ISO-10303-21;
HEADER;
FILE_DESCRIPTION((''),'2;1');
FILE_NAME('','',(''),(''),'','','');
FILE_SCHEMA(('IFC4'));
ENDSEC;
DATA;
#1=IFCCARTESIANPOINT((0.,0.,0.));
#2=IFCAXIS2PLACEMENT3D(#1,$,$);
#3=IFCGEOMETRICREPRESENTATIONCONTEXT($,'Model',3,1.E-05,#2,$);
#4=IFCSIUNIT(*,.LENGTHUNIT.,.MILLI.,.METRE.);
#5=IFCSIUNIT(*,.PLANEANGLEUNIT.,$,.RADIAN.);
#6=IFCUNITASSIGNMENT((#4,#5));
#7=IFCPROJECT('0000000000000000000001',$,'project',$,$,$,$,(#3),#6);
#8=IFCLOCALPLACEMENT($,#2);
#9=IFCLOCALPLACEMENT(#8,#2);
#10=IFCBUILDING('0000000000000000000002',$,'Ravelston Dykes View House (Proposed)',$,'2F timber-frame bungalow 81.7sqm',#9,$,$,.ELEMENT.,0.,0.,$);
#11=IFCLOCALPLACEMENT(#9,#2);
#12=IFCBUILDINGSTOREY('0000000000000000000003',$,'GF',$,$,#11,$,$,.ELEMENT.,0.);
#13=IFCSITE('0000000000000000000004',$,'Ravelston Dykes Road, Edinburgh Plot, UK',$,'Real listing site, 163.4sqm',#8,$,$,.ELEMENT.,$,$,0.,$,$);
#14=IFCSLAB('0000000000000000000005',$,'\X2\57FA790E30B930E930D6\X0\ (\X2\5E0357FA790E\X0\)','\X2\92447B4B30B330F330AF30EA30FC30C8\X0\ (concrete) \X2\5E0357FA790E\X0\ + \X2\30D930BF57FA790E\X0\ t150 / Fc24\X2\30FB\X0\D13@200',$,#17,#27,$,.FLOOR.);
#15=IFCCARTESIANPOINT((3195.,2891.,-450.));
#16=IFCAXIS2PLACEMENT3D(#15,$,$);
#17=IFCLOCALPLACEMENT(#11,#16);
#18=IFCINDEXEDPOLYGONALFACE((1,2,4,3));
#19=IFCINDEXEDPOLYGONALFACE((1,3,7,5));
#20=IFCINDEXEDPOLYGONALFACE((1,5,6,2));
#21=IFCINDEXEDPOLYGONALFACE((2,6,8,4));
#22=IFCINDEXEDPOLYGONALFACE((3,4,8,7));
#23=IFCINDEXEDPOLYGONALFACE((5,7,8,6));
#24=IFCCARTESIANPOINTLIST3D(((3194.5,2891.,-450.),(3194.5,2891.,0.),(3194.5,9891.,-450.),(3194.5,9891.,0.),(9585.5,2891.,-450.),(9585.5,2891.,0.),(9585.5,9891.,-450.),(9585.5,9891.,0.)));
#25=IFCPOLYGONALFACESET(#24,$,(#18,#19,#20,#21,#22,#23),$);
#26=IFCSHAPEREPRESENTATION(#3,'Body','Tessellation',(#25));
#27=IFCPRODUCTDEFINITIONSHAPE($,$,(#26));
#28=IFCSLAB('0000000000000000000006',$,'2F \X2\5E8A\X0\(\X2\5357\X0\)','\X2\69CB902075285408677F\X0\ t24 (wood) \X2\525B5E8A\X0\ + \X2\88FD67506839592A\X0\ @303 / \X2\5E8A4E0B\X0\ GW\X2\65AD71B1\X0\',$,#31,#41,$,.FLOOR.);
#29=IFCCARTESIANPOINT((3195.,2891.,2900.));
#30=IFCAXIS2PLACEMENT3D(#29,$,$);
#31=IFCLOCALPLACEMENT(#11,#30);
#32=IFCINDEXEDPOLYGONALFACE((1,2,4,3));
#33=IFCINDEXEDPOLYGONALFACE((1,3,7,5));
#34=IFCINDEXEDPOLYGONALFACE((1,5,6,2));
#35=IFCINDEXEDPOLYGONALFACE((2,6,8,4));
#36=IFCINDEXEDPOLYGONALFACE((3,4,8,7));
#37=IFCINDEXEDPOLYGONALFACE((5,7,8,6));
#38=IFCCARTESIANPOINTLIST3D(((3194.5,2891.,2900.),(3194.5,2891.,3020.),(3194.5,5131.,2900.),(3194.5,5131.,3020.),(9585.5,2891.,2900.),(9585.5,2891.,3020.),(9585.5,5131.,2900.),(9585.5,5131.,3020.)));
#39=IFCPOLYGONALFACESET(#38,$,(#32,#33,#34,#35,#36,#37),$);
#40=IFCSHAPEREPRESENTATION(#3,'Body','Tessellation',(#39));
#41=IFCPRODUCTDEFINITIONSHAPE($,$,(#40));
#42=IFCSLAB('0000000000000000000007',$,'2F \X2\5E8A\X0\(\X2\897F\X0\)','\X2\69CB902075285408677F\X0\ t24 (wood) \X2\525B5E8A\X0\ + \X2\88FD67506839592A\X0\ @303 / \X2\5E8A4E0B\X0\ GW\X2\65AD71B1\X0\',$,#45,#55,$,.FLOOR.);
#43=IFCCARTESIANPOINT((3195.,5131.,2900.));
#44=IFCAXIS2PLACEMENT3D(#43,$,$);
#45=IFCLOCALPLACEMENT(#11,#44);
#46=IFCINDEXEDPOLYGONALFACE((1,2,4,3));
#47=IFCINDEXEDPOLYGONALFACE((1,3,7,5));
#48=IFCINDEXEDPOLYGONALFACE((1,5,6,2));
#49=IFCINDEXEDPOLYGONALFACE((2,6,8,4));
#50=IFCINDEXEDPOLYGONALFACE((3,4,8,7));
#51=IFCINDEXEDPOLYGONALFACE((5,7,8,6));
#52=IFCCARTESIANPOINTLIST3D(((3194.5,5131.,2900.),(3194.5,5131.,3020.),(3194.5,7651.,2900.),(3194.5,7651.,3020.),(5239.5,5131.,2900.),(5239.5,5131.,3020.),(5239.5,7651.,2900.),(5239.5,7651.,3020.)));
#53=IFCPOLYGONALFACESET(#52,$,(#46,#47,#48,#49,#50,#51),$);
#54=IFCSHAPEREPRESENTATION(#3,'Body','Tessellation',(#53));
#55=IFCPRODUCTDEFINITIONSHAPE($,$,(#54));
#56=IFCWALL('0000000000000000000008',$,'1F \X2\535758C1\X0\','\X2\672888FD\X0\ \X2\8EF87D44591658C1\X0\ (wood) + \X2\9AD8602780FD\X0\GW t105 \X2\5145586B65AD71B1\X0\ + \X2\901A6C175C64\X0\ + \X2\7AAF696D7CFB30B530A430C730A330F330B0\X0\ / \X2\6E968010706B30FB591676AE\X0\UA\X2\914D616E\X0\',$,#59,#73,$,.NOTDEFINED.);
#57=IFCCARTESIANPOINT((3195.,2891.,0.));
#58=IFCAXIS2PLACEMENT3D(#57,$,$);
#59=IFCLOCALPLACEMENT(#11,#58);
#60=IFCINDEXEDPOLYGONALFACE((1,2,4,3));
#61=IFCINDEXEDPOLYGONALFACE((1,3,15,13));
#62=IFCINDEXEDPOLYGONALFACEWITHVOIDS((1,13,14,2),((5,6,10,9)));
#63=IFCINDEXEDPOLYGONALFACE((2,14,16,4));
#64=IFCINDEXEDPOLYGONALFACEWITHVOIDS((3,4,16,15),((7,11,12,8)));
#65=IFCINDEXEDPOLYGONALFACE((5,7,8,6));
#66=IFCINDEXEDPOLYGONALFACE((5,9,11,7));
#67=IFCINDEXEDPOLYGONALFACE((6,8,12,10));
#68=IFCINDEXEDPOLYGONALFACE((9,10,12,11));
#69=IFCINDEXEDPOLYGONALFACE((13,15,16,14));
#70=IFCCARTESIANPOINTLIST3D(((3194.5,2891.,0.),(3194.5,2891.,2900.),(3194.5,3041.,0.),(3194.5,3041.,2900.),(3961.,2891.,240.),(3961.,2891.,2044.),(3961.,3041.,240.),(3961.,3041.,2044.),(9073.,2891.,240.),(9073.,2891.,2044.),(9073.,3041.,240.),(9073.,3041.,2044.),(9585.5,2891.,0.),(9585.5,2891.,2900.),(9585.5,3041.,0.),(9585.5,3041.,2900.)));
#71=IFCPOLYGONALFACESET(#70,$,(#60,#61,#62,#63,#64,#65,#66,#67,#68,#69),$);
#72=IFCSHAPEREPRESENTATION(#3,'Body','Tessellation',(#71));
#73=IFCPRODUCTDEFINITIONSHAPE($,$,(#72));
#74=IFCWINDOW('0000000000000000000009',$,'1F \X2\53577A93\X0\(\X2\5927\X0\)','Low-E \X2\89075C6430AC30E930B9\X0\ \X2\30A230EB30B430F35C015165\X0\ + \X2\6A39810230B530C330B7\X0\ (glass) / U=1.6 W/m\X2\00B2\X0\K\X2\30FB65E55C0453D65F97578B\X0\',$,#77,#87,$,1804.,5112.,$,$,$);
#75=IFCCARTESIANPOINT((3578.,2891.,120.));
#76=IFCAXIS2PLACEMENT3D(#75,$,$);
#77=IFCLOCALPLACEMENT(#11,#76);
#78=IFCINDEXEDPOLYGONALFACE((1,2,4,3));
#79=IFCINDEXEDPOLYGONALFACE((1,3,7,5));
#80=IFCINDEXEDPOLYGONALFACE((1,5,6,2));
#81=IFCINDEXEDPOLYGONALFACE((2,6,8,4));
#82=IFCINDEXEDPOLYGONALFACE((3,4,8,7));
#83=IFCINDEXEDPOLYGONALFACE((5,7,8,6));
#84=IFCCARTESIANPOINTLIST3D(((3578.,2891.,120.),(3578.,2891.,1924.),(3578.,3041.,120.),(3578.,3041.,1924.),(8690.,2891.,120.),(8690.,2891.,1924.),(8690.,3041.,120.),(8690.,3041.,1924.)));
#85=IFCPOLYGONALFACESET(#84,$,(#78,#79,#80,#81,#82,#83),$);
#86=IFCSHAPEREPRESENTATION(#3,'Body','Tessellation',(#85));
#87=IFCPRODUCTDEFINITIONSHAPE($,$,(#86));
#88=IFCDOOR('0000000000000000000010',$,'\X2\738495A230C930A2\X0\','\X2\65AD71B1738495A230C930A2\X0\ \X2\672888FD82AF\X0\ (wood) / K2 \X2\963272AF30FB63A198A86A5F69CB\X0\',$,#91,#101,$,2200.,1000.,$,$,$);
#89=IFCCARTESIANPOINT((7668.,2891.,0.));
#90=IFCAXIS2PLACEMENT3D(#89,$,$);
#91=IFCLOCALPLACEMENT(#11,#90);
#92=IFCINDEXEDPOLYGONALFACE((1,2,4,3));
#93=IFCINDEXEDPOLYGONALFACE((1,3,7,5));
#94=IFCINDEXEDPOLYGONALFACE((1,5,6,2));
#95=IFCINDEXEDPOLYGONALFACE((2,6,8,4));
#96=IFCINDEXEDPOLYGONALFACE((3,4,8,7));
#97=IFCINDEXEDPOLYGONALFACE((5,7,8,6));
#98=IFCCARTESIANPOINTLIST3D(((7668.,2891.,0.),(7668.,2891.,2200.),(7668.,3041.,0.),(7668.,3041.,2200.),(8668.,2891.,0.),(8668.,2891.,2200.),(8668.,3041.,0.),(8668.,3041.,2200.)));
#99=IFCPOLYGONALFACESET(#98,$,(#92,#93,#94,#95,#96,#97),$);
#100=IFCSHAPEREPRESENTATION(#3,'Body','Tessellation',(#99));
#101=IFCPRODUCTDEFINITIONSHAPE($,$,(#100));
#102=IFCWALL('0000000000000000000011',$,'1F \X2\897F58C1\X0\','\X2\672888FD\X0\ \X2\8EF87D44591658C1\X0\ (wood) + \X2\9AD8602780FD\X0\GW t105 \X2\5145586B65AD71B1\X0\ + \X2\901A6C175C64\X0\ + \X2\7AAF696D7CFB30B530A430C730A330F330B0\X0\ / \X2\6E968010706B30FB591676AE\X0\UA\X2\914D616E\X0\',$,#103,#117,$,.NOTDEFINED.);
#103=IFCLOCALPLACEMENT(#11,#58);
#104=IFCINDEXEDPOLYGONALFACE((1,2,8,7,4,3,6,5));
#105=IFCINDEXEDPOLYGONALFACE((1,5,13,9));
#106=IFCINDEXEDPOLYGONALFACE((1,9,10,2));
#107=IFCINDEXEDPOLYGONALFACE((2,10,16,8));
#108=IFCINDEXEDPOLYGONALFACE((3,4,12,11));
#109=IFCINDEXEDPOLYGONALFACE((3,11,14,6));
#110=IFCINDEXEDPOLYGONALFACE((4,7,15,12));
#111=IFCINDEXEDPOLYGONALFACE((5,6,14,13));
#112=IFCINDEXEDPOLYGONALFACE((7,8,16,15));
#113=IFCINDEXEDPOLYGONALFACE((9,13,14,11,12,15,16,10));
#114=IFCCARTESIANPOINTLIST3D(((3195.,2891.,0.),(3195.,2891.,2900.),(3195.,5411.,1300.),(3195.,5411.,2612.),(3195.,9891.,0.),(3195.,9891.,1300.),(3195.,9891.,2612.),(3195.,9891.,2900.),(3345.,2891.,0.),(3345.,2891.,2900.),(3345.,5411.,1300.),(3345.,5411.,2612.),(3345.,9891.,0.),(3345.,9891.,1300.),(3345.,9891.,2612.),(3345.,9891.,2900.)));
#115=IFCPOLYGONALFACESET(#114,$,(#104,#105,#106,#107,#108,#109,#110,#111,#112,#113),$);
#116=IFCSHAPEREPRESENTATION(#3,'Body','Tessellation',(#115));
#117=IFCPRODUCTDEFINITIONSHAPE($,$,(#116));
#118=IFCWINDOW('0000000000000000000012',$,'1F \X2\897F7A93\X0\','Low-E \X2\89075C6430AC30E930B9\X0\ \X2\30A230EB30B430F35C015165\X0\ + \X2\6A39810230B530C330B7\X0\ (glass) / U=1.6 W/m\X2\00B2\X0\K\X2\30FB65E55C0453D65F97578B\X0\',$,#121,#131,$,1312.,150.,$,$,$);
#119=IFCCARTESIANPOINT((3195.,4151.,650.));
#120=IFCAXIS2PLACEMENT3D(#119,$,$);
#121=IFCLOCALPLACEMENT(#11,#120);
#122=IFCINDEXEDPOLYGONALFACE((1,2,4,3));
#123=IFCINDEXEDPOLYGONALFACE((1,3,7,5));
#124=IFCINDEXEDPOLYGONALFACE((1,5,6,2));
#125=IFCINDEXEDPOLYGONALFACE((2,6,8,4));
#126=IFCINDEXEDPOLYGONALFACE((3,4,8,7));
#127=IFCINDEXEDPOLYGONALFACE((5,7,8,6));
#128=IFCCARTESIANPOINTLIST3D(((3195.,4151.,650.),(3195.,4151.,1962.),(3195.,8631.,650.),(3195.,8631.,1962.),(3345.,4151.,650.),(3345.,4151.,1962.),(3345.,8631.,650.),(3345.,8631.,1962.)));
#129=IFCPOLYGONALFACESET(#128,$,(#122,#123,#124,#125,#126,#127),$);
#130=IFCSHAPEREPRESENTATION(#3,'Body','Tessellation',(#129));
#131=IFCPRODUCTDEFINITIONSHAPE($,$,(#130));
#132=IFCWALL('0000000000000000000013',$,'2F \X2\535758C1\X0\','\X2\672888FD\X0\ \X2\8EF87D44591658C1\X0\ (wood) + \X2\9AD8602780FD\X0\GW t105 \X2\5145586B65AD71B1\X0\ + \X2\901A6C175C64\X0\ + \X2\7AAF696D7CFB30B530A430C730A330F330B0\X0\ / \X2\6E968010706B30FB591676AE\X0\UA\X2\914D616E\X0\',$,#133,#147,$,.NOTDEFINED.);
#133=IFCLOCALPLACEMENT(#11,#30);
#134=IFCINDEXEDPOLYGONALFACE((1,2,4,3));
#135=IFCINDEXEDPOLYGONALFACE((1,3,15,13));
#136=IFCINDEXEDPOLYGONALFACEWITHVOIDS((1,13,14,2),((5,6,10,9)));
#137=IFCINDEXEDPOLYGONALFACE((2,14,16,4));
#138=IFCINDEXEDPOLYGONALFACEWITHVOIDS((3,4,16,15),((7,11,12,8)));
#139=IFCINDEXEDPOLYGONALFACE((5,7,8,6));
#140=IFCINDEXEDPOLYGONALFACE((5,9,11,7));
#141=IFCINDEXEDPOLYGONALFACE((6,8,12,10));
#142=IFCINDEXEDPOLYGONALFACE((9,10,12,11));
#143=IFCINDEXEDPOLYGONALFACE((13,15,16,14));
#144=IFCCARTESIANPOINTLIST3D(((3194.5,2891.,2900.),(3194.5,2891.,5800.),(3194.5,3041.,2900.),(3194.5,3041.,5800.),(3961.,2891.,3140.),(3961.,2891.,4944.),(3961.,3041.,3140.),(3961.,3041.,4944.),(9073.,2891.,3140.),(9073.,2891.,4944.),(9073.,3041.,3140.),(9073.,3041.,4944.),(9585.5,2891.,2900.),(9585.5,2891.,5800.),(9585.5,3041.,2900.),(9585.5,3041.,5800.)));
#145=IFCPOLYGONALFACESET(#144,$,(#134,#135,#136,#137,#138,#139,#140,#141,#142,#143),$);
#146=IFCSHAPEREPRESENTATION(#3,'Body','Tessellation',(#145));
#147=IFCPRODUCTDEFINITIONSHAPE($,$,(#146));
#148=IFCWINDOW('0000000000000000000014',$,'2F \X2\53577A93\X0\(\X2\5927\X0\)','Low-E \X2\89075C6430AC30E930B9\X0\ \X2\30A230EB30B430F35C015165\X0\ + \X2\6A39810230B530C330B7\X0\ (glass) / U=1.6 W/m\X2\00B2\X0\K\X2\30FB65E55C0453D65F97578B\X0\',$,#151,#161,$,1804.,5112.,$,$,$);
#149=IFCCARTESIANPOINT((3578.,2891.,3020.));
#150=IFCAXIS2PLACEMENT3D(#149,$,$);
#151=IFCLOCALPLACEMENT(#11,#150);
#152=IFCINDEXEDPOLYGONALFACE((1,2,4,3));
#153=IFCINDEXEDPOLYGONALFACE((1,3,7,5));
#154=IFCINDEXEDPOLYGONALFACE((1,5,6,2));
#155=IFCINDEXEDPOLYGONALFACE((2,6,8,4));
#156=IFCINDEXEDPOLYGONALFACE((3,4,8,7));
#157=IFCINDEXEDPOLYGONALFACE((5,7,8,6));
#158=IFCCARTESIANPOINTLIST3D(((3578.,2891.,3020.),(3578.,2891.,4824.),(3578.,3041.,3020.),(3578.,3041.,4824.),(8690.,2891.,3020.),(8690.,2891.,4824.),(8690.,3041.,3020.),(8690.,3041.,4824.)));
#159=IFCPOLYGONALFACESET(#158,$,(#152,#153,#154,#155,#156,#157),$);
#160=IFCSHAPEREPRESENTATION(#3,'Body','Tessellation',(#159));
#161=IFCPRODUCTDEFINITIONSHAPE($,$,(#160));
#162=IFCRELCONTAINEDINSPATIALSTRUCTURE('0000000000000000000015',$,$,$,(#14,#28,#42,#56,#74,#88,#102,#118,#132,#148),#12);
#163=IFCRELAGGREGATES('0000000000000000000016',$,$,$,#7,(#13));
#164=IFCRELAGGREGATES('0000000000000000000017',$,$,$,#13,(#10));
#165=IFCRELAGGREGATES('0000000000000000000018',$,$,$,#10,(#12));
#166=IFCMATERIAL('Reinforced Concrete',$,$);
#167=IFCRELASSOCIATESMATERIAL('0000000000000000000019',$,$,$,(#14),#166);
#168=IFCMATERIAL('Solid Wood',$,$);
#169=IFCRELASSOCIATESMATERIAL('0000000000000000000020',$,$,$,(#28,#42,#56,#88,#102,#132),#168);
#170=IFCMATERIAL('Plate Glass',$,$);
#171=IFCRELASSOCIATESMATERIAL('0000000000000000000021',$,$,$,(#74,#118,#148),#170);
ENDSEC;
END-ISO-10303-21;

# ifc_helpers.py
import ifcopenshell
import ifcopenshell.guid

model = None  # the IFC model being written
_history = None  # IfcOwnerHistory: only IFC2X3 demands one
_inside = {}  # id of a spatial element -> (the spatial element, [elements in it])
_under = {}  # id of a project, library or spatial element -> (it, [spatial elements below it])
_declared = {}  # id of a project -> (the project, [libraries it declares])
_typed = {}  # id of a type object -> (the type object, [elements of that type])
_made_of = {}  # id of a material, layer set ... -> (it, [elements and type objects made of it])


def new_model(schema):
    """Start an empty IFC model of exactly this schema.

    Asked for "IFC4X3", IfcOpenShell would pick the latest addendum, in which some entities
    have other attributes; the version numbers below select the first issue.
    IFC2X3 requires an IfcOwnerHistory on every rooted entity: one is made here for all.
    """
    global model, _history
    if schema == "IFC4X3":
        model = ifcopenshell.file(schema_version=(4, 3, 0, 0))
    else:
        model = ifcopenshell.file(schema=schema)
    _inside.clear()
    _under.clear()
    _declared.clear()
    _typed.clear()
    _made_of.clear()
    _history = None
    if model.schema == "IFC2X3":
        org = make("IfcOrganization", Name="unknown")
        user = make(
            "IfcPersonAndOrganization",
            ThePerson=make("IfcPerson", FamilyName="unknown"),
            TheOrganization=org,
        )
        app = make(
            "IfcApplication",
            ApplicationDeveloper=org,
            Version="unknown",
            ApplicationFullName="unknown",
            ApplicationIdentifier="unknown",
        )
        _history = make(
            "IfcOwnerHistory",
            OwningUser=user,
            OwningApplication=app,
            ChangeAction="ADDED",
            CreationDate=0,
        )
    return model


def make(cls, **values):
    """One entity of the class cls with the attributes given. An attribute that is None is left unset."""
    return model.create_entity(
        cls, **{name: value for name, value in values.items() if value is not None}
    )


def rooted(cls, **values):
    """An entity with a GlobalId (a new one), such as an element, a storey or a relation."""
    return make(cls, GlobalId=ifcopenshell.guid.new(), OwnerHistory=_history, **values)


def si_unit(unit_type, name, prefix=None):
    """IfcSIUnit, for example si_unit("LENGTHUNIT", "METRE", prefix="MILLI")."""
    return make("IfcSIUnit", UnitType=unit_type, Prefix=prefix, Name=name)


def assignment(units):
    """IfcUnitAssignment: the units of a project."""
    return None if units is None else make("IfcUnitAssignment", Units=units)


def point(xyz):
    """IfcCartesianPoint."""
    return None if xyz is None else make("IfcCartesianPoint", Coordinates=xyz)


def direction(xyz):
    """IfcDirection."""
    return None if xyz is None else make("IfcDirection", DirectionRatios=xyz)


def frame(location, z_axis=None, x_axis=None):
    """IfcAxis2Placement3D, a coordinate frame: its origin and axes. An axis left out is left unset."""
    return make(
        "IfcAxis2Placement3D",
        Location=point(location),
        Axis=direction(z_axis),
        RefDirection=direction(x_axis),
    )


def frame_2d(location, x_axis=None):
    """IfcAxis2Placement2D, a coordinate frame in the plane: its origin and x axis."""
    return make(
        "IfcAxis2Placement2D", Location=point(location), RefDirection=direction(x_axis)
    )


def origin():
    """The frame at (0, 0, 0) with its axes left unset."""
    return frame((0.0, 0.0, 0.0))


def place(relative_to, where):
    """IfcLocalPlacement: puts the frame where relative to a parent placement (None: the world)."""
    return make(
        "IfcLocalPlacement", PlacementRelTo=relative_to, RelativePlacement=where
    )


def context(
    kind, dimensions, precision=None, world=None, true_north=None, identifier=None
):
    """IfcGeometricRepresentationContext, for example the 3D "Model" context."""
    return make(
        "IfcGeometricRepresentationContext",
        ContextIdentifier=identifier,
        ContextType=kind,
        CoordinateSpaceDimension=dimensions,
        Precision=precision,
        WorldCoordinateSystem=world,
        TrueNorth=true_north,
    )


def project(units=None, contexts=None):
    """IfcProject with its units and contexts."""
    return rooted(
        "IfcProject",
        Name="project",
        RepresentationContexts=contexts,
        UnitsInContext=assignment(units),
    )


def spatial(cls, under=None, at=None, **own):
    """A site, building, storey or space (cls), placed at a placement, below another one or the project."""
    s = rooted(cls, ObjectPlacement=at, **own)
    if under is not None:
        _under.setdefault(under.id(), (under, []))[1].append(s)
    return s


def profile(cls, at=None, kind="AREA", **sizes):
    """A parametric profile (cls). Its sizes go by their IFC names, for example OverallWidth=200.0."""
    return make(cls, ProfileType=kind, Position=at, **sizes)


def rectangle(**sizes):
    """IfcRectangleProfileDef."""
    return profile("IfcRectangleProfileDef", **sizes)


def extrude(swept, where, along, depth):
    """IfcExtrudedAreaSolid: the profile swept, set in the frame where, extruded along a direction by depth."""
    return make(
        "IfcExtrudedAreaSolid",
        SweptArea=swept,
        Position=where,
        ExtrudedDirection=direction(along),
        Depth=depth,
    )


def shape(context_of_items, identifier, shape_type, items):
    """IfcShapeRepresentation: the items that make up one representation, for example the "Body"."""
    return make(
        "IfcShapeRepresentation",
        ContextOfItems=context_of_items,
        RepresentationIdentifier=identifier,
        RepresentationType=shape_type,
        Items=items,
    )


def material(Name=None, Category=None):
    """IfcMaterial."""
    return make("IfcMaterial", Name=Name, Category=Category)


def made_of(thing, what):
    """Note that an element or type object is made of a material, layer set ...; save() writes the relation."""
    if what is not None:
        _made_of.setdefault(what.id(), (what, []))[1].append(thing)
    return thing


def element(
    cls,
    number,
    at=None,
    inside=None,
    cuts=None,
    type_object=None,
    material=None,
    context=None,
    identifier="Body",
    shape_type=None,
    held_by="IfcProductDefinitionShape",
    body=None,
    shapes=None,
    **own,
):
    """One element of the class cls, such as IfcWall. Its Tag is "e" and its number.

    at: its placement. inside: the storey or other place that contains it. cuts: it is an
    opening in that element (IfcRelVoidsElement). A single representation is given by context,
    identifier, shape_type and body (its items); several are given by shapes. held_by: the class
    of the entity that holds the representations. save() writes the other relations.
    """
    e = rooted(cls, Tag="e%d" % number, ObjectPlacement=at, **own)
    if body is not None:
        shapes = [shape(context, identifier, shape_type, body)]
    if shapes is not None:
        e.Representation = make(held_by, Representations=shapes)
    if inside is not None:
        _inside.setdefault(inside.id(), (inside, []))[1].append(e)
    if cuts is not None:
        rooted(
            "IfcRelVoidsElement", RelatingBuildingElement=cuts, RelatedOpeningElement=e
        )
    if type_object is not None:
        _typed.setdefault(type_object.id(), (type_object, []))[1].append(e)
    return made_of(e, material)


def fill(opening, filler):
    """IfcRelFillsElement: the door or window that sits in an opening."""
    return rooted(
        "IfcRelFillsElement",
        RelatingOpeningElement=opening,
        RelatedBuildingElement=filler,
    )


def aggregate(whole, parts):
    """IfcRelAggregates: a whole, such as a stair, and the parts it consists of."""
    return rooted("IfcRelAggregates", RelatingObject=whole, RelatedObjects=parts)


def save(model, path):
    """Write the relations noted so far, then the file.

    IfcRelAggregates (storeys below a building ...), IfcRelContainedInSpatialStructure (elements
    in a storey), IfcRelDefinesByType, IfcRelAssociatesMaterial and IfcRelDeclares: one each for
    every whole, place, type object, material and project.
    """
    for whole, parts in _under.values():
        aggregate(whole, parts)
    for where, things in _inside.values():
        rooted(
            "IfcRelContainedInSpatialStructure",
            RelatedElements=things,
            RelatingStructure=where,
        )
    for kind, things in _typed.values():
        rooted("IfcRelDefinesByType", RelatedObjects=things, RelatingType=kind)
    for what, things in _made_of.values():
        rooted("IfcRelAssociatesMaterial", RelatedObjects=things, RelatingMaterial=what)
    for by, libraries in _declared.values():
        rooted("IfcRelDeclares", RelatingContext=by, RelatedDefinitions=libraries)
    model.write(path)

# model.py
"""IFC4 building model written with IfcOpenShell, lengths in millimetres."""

from ifc_helpers import new_model, si_unit, frame, frame_2d, origin, place, context, project, spatial, rectangle, extrude, material, element, fill, save


model = new_model("IFC4")

# Units and contexts
model_context = context("Model", 3, precision=1e-05, world=origin())
ifc_project = project(units=[si_unit("LENGTHUNIT", "METRE", prefix="MILLI"), si_unit("PLANEANGLEUNIT", "RADIAN")], contexts=[model_context])

# Site, building, storey
site_placement = place(None, origin())
site = spatial("IfcSite", under=ifc_project, at=site_placement, Name="Ravelston Dykes Road, Edinburgh Plot, UK", ObjectType="Real listing site, 163.4sqm", CompositionType="ELEMENT", RefElevation=0.0)
building_placement = place(site_placement, origin())
building = spatial("IfcBuilding", under=site, at=building_placement, Name="Ravelston Dykes View House (Proposed)", ObjectType="2F timber-frame bungalow 81.7sqm", CompositionType="ELEMENT", ElevationOfRefHeight=0.0, ElevationOfTerrain=0.0)
storey_placement = place(building_placement, origin())
storey = spatial("IfcBuildingStorey", under=building, at=storey_placement, Name="GF", CompositionType="ELEMENT", Elevation=0.0)

# Slabs
ifc_material_1 = material(Name="Reinforced Concrete")
slab_1_placement = place(storey_placement, frame((3195.0, 2891.0, -450.0)))
element("IfcSlab", 1, at=slab_1_placement, inside=storey, material=ifc_material_1, Name="基礎スラブ (布基礎)", Description="鉄筋コンクリート (concrete) 布基礎 + ベタ基礎 t150 / Fc24・D13@200", PredefinedType="FLOOR", context=model_context, shape_type="SweptSolid", body=[
    extrude(rectangle(XDim=6391.0, YDim=7000.0, at=frame_2d((3195.0, 3500.0))), frame((3195.0, 2891.0, -450.0)), (0.0, 0.0, 1.0), 450.0),
])
ifc_material_2 = material(Name="Solid Wood")
slab_2_placement = place(storey_placement, frame((3195.0, 2891.0, 2900.0)))
element("IfcSlab", 2, at=slab_2_placement, inside=storey, material=ifc_material_2, Name="2F 床(南)", Description="構造用合板 t24 (wood) 剛床 + 製材根太 @303 / 床下 GW断熱", PredefinedType="FLOOR", context=model_context, shape_type="SweptSolid", body=[
    extrude(rectangle(XDim=6391.0, YDim=2240.0, at=frame_2d((3195.0, 1120.0))), frame((3195.0, 2891.0, 2900.0)), (0.0, 0.0, 1.0), 120.0),
])
slab_3_placement = place(storey_placement, frame((3195.0, 5131.0, 2900.0)))
element("IfcSlab", 3, at=slab_3_placement, inside=storey, material=ifc_material_2, Name="2F 床(西)", Description="構造用合板 t24 (wood) 剛床 + 製材根太 @303 / 床下 GW断熱", PredefinedType="FLOOR", context=model_context, shape_type="SweptSolid", body=[
    extrude(rectangle(XDim=2045.0, YDim=2520.0, at=frame_2d((1022.0, 1260.0))), frame((3195.0, 5131.0, 2900.0)), (0.0, 0.0, 1.0), 120.0),
])

# Wall, openings, window, door
wall_1_placement = place(storey_placement, frame((3195.0, 2891.0, 0.0)))
wall_1 = element("IfcWall", 4, at=wall_1_placement, inside=storey, material=ifc_material_2, Name="1F 南壁", Description="木製 軸組外壁 (wood) + 高性能GW t105 充填断熱 + 通気層 + 窯業系サイディング / 準耐火・外皮UA配慮", PredefinedType="NOTDEFINED", context=model_context, shape_type="SweptSolid", body=[
    extrude(rectangle(XDim=6391.0, YDim=150.0, at=frame_2d((3195.0, 75.0))), frame((3195.0, 2891.0, 0.0)), (0.0, 0.0, 1.0), 2900.0),
])
opening_1_placement = place(storey_placement, frame((3578.0, 2891.0, 120.0)))
opening_1 = element("IfcOpeningElement", 5, at=opening_1_placement, cuts=wall_1, PredefinedType="NOTDEFINED", context=model_context, shape_type="SweptSolid", body=[
    extrude(rectangle(XDim=5112.0, YDim=150.0, at=frame_2d((2556.0, 75.0))), frame((3578.0, 2891.0, 120.0)), (0.0, 0.0, 1.0), 1804.0),
])
opening_2_placement = place(storey_placement, frame((7668.0, 2891.0, 0.0)))
opening_2 = element("IfcOpeningElement", 6, at=opening_2_placement, cuts=wall_1, PredefinedType="NOTDEFINED", context=model_context, shape_type="SweptSolid", body=[
    extrude(rectangle(XDim=1000.0, YDim=150.0, at=frame_2d((500.0, 75.0))), frame((7668.0, 2891.0, 0.0)), (0.0, 0.0, 1.0), 2200.0),
])
ifc_material_3 = material(Name="Plate Glass")
window_1_placement = place(storey_placement, frame((3578.0, 2891.0, 120.0)))
window_1 = element("IfcWindow", 7, at=window_1_placement, inside=storey, material=ifc_material_3, Name="1F 南窓(大)", Description="Low-E 複層ガラス アルゴン封入 + 樹脂サッシ (glass) / U=1.6 W/m²K・日射取得型", OverallHeight=1804.0, OverallWidth=5112.0, context=model_context, shape_type="SweptSolid", body=[
    extrude(rectangle(XDim=5112.0, YDim=150.0, at=frame_2d((2556.0, 75.0))), frame((3578.0, 2891.0, 120.0)), (0.0, 0.0, 1.0), 1804.0),
])
fill(opening_1, window_1)
door_placement = place(storey_placement, frame((7668.0, 2891.0, 0.0)))
door = element("IfcDoor", 8, at=door_placement, inside=storey, material=ifc_material_2, Name="玄関ドア", Description="断熱玄関ドア 木製芯 (wood) / K2 防犯・採風機構", OverallHeight=2200.0, OverallWidth=1000.0, context=model_context, shape_type="SweptSolid", body=[
    extrude(rectangle(XDim=1000.0, YDim=150.0, at=frame_2d((500.0, 75.0))), frame((7668.0, 2891.0, 0.0)), (0.0, 0.0, 1.0), 2200.0),
])
fill(opening_2, door)

# Walls, openings, windows
wall_2_placement = place(storey_placement, frame((3195.0, 2891.0, 0.0)))
wall_2 = element("IfcWall", 9, at=wall_2_placement, inside=storey, material=ifc_material_2, Name="1F 西壁", Description="木製 軸組外壁 (wood) + 高性能GW t105 充填断熱 + 通気層 + 窯業系サイディング / 準耐火・外皮UA配慮", PredefinedType="NOTDEFINED", context=model_context, shape_type="SweptSolid", body=[
    extrude(rectangle(XDim=150.0, YDim=7000.0, at=frame_2d((75.0, 3500.0))), frame((3195.0, 2891.0, 0.0)), (0.0, 0.0, 1.0), 2900.0),
])
opening_3_placement = place(storey_placement, frame((3195.0, 4151.0, 650.0)))
opening_3 = element("IfcOpeningElement", 10, at=opening_3_placement, cuts=wall_2, PredefinedType="NOTDEFINED", context=model_context, shape_type="SweptSolid", body=[
    extrude(rectangle(XDim=150.0, YDim=4480.0, at=frame_2d((75.0, 2240.0))), frame((3195.0, 4151.0, 650.0)), (0.0, 0.0, 1.0), 1312.0),
])
window_2_placement = place(storey_placement, frame((3195.0, 4151.0, 650.0)))
window_2 = element("IfcWindow", 11, at=window_2_placement, inside=storey, material=ifc_material_3, Name="1F 西窓", Description="Low-E 複層ガラス アルゴン封入 + 樹脂サッシ (glass) / U=1.6 W/m²K・日射取得型", OverallHeight=1312.0, OverallWidth=150.0, context=model_context, shape_type="SweptSolid", body=[
    extrude(rectangle(XDim=150.0, YDim=4480.0, at=frame_2d((75.0, 2240.0))), frame((3195.0, 4151.0, 650.0)), (0.0, 0.0, 1.0), 1312.0),
])
fill(opening_3, window_2)
wall_3_placement = place(storey_placement, frame((3195.0, 2891.0, 2900.0)))
wall_3 = element("IfcWall", 12, at=wall_3_placement, inside=storey, material=ifc_material_2, Name="2F 南壁", Description="木製 軸組外壁 (wood) + 高性能GW t105 充填断熱 + 通気層 + 窯業系サイディング / 準耐火・外皮UA配慮", PredefinedType="NOTDEFINED", context=model_context, shape_type="SweptSolid", body=[
    extrude(rectangle(XDim=6391.0, YDim=150.0, at=frame_2d((3195.0, 75.0))), frame((3195.0, 2891.0, 2900.0)), (0.0, 0.0, 1.0), 2900.0),
])
opening_4_placement = place(storey_placement, frame((3578.0, 2891.0, 3020.0)))
opening_4 = element("IfcOpeningElement", 13, at=opening_4_placement, cuts=wall_3, PredefinedType="NOTDEFINED", context=model_context, shape_type="SweptSolid", body=[
    extrude(rectangle(XDim=5112.0, YDim=150.0, at=frame_2d((2556.0, 75.0))), frame((3578.0, 2891.0, 3020.0)), (0.0, 0.0, 1.0), 1804.0),
])
window_3_placement = place(storey_placement, frame((3578.0, 2891.0, 3020.0)))
window_3 = element("IfcWindow", 14, at=window_3_placement, inside=storey, material=ifc_material_3, Name="2F 南窓(大)", Description="Low-E 複層ガラス アルゴン封入 + 樹脂サッシ (glass) / U=1.6 W/m²K・日射取得型", OverallHeight=1804.0, OverallWidth=5112.0, context=model_context, shape_type="SweptSolid", body=[
    extrude(rectangle(XDim=5112.0, YDim=150.0, at=frame_2d((2556.0, 75.0))), frame((3578.0, 2891.0, 3020.0)), (0.0, 0.0, 1.0), 1804.0),
])
fill(opening_4, window_3)

save(model, "model.ifc")
